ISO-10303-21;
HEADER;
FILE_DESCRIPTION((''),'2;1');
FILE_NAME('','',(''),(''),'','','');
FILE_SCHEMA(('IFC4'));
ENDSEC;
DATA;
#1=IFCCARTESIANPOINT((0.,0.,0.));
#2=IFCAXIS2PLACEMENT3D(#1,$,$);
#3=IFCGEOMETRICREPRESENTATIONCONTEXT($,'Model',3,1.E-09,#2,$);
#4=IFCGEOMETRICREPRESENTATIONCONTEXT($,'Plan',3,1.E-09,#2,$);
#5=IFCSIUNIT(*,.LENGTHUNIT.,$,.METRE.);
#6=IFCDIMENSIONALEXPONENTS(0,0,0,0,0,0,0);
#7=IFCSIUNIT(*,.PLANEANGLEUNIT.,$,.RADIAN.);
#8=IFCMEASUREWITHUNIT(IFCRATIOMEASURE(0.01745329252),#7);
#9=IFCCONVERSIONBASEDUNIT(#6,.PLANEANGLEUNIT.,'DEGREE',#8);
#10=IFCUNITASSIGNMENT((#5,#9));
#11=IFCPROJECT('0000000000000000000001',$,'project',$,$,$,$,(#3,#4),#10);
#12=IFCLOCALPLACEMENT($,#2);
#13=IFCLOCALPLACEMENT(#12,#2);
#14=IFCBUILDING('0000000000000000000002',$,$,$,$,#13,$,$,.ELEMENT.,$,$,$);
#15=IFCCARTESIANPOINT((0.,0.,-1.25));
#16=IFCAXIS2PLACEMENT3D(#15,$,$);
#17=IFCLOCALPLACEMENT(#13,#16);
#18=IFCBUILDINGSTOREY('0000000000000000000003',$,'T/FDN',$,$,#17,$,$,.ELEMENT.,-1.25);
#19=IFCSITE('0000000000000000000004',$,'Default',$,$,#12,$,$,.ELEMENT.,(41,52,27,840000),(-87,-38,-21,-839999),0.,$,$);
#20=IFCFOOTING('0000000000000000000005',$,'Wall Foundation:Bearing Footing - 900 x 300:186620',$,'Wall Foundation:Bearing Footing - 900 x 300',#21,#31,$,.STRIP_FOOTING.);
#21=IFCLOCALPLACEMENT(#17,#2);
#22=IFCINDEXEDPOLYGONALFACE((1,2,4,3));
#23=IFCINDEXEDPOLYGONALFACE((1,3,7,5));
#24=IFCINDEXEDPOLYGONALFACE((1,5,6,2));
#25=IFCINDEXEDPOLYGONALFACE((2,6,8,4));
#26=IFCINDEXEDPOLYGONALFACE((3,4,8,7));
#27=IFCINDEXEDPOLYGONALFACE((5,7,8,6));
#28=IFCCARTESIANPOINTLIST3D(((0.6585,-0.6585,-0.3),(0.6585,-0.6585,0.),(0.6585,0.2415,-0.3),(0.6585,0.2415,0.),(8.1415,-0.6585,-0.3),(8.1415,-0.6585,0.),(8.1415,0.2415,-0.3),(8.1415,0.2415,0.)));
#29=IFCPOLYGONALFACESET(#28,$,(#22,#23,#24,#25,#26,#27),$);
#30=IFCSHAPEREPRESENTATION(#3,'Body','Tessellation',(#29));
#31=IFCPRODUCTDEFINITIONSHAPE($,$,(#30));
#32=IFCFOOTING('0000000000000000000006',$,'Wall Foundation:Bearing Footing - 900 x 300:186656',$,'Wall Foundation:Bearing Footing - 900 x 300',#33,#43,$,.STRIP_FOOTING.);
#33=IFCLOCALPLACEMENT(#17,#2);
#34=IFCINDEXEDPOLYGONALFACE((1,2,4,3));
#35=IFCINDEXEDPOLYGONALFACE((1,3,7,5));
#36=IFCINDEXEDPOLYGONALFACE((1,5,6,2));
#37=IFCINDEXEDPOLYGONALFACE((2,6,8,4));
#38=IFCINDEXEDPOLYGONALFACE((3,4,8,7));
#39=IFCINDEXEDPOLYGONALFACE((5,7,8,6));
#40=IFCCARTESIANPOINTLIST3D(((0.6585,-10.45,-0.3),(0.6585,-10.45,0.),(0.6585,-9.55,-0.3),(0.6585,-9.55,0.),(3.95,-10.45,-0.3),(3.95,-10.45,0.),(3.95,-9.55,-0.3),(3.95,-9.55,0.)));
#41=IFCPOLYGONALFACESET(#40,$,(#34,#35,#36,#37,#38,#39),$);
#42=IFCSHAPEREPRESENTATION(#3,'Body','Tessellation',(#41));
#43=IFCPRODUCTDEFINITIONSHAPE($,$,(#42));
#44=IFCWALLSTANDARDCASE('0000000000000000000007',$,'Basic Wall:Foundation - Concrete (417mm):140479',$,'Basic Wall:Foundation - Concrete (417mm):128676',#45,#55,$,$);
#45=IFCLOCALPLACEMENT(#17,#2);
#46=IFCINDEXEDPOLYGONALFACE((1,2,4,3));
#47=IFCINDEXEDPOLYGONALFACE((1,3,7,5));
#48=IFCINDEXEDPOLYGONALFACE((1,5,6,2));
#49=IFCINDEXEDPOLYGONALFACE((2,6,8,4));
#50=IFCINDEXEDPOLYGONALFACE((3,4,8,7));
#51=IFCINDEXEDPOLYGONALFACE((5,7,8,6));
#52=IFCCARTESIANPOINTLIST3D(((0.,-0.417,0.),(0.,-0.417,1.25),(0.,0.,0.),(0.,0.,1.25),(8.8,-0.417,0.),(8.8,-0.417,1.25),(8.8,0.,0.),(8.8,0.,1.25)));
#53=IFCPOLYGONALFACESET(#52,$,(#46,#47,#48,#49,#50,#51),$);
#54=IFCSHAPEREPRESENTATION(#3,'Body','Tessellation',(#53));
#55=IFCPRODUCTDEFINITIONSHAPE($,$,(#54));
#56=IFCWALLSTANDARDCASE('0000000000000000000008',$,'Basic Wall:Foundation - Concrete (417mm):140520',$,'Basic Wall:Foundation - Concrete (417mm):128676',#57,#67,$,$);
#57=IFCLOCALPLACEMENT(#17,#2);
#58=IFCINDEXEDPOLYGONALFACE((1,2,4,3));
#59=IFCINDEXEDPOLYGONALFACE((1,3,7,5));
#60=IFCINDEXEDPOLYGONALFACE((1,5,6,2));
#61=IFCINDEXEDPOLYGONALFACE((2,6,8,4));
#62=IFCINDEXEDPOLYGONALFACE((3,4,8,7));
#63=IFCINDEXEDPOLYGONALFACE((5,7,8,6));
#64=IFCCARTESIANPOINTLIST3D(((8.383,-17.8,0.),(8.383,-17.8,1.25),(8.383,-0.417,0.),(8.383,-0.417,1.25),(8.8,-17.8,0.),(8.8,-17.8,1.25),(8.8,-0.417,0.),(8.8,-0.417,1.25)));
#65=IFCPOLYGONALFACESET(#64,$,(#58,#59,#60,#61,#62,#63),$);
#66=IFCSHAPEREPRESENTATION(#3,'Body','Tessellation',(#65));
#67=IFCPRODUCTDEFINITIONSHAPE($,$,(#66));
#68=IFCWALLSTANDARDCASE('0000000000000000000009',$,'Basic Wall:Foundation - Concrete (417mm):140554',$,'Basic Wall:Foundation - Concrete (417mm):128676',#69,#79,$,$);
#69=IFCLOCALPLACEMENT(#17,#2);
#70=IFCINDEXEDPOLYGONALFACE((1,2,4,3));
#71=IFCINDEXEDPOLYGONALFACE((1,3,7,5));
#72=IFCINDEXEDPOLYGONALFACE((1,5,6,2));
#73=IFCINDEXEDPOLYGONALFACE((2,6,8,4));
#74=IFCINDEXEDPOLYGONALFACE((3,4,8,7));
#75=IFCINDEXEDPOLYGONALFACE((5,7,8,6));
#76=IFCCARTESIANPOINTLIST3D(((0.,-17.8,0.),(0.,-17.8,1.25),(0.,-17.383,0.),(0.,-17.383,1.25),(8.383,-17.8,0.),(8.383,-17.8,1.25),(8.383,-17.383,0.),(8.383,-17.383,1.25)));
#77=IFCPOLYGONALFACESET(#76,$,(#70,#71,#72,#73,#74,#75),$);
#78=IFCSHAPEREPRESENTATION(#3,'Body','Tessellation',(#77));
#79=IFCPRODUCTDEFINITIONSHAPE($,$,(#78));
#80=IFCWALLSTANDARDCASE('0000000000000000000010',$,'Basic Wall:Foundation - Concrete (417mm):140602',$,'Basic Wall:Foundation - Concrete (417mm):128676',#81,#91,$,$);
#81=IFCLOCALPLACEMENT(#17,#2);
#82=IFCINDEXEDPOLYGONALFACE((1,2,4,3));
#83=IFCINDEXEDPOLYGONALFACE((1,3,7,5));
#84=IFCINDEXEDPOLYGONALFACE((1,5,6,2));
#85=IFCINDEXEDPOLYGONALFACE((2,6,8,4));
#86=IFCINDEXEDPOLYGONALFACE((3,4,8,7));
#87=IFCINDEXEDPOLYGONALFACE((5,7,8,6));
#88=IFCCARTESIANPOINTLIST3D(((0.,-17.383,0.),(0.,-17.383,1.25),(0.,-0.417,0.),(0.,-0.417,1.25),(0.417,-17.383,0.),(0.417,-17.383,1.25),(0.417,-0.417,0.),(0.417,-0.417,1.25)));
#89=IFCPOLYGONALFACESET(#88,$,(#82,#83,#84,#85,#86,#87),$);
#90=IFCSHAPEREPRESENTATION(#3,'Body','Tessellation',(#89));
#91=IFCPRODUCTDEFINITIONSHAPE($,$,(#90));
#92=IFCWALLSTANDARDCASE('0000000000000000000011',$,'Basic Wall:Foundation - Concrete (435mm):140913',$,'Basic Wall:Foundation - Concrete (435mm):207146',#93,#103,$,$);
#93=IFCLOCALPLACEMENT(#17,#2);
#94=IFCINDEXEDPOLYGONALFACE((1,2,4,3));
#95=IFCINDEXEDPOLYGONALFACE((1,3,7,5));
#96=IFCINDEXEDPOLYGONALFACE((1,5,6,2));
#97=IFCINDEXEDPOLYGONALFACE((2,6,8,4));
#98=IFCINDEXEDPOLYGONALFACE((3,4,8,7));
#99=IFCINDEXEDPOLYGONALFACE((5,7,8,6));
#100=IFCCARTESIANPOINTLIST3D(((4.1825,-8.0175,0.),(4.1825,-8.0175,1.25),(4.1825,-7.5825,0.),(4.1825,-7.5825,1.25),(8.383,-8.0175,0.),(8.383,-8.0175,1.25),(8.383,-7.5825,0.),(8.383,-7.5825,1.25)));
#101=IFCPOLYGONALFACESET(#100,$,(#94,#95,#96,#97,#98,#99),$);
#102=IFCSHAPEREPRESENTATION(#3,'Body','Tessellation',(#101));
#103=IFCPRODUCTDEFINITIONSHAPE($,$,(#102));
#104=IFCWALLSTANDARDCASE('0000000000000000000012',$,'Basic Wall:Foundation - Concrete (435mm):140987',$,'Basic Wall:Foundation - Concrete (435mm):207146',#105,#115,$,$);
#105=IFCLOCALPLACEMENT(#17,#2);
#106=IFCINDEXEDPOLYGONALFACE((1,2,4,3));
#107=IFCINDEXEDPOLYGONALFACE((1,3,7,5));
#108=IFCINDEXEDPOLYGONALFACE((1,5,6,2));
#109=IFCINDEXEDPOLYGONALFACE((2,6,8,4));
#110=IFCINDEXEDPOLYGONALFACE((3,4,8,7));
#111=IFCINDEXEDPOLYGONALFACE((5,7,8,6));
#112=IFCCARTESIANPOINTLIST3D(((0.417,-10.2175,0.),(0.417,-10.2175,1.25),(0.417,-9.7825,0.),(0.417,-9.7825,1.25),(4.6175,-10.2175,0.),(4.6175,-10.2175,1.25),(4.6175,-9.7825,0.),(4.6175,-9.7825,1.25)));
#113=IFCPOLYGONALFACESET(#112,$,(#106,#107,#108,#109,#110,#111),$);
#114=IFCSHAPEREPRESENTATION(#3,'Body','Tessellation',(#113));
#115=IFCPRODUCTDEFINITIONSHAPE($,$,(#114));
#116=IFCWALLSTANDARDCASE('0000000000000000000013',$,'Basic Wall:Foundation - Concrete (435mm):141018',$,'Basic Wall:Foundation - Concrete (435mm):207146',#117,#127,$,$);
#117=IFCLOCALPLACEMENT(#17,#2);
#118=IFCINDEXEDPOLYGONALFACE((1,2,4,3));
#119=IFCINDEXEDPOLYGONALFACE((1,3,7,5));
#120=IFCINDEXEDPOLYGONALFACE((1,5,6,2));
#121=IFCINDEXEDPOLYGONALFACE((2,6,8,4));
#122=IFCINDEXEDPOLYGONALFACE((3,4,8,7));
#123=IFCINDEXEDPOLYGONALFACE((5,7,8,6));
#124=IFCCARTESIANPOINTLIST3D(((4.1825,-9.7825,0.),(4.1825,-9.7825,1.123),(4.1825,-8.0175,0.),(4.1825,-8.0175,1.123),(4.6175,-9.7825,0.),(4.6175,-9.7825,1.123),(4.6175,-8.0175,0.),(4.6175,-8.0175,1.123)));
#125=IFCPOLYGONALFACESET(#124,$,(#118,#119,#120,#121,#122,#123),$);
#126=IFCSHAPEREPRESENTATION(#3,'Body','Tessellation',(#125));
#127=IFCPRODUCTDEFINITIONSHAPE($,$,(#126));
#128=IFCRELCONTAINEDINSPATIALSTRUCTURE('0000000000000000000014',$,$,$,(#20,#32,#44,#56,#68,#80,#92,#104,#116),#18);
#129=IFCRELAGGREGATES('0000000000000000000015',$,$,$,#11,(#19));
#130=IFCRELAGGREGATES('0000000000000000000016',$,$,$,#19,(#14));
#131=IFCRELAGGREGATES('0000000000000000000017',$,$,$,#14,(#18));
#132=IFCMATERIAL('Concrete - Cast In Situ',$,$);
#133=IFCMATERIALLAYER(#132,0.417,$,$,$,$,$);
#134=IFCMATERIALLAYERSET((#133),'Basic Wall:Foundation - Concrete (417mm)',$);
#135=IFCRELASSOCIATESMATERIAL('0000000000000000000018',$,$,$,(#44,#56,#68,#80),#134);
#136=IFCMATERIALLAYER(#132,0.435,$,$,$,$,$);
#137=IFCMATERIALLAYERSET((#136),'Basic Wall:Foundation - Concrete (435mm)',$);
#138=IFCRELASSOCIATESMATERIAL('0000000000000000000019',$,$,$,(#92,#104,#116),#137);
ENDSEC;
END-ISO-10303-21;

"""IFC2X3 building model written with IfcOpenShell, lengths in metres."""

from ifc_helpers import new_model, entity, si_unit, converted_unit, frame, frame_2d, origin, origin_2d_with_axis, place, context, project, spatial, rectangle, extrude, material, layer, layer_set, layer_usage, element, save


model = new_model("IFC2X3")

# Units and contexts
model_context = context("Model", 3, precision=1e-09, world=origin())
plan_context = context("Plan", 3, precision=1e-09, world=origin())
ifc_project = project(units=[si_unit("LENGTHUNIT", "METRE"), converted_unit("PLANEANGLEUNIT", "DEGREE", entity("IfcRatioMeasure", 0.01745329252), si_unit("PLANEANGLEUNIT", "RADIAN"), dimensions=[0, 0, 0, 0, 0, 0, 0])], contexts=[model_context, plan_context])

# Site, building, storey
site_placement = place(None, origin())
site = spatial("IfcSite", under=ifc_project, at=site_placement, Name="Default", CompositionType="ELEMENT", RefLatitude=(41, 52, 27, 840000), RefLongitude=(-87, -38, -21, -839999), RefElevation=0.0)
building_placement = place(site_placement, origin())
building = spatial("IfcBuilding", under=site, at=building_placement, CompositionType="ELEMENT")
storey_placement = place(building_placement, frame((0.0, 0.0, -1.25)))
storey = spatial("IfcBuildingStorey", under=building, at=storey_placement, Name="T/FDN", CompositionType="ELEMENT", Elevation=-1.25)

# Footings
footing_1_placement = place(storey_placement, origin())
element("IfcFooting", 1, at=footing_1_placement, inside=storey, Name="Wall Foundation:Bearing Footing - 900 x 300:186620", ObjectType="Wall Foundation:Bearing Footing - 900 x 300", PredefinedType="STRIP_FOOTING", context=model_context, shape_type="SweptSolid", body=[
    extrude(rectangle(XDim=7.483, YDim=0.9, at=origin_2d_with_axis()), frame((4.4, -0.2085, -0.3), z_axis=(0.0, 0.0, 1.0), x_axis=(-1.0, 0.0, 0.0)), (0.0, 0.0, 1.0), 0.3),
])
footing_2_placement = place(storey_placement, origin())
element("IfcFooting", 2, at=footing_2_placement, inside=storey, Name="Wall Foundation:Bearing Footing - 900 x 300:186656", ObjectType="Wall Foundation:Bearing Footing - 900 x 300", PredefinedType="STRIP_FOOTING", context=model_context, shape_type="SweptSolid", body=[
    extrude(rectangle(XDim=3.2915, YDim=0.9, at=origin_2d_with_axis()), frame((2.3043, -10.0, -0.3)), (0.0, 0.0, 1.0), 0.3),
])

# Walls
ifc_material = material(Name="Concrete - Cast In Situ")
ifc_layer_1 = layer(ifc_material, 0.417)
ifc_layer_set_1 = layer_set([ifc_layer_1], Name="Basic Wall:Foundation - Concrete (417mm)")
ifc_layer_usage_1 = layer_usage(ifc_layer_set_1, "AXIS2", "NEGATIVE", 0.2085)
wall_1_placement = place(storey_placement, frame((0.0, -0.2085, 0.0)))
element("IfcWallStandardCase", 3, at=wall_1_placement, inside=storey, material=ifc_layer_usage_1, Name="Basic Wall:Foundation - Concrete (417mm):140479", ObjectType="Basic Wall:Foundation - Concrete (417mm):128676", context=model_context, shape_type="SweptSolid", body=[
    extrude(rectangle(XDim=8.8, YDim=0.417, at=frame_2d((4.4, 0.0), x_axis=(-1.0, 0.0))), origin(), (0.0, 0.0, 1.0), 1.25),
])
ifc_layer_usage_2 = layer_usage(ifc_layer_set_1, "AXIS2", "NEGATIVE", 0.2085)
wall_2_placement = place(storey_placement, frame((8.5915, -0.417, 0.0), z_axis=(0.0, 0.0, 1.0), x_axis=(0.0, -1.0, 0.0)))
element("IfcWallStandardCase", 4, at=wall_2_placement, inside=storey, material=ifc_layer_usage_2, Name="Basic Wall:Foundation - Concrete (417mm):140520", ObjectType="Basic Wall:Foundation - Concrete (417mm):128676", context=model_context, shape_type="SweptSolid", body=[
    extrude(rectangle(XDim=17.383, YDim=0.417, at=frame_2d((8.6915, 0.0), x_axis=(-1.0, 0.0))), origin(), (0.0, 0.0, 1.0), 1.25),
])
ifc_layer_usage_3 = layer_usage(ifc_layer_set_1, "AXIS2", "NEGATIVE", 0.2085)
wall_3_placement = place(storey_placement, frame((8.383, -17.5915, 0.0), z_axis=(0.0, 0.0, 1.0), x_axis=(-1.0, 0.0, 0.0)))
element("IfcWallStandardCase", 5, at=wall_3_placement, inside=storey, material=ifc_layer_usage_3, Name="Basic Wall:Foundation - Concrete (417mm):140554", ObjectType="Basic Wall:Foundation - Concrete (417mm):128676", context=model_context, shape_type="SweptSolid", body=[
    extrude(rectangle(XDim=8.383, YDim=0.417, at=frame_2d((4.1915, 0.0), x_axis=(-1.0, 0.0))), origin(), (0.0, 0.0, 1.0), 1.25),
])
ifc_layer_usage_4 = layer_usage(ifc_layer_set_1, "AXIS2", "NEGATIVE", 0.2085)
wall_4_placement = place(storey_placement, frame((0.2085, -17.383, 0.0), z_axis=(0.0, 0.0, 1.0), x_axis=(0.0, 1.0, 0.0)))
element("IfcWallStandardCase", 6, at=wall_4_placement, inside=storey, material=ifc_layer_usage_4, Name="Basic Wall:Foundation - Concrete (417mm):140602", ObjectType="Basic Wall:Foundation - Concrete (417mm):128676", context=model_context, shape_type="SweptSolid", body=[
    extrude(rectangle(XDim=16.966, YDim=0.417, at=frame_2d((8.483, 0.0), x_axis=(-1.0, 0.0))), origin(), (0.0, 0.0, 1.0), 1.25),
])
ifc_layer_2 = layer(ifc_material, 0.435)
ifc_layer_set_2 = layer_set([ifc_layer_2], Name="Basic Wall:Foundation - Concrete (435mm)")
ifc_layer_usage_5 = layer_usage(ifc_layer_set_2, "AXIS2", "NEGATIVE", 0.2175)
wall_5_placement = place(storey_placement, frame((8.383, -7.8, 0.0), z_axis=(0.0, 0.0, 1.0), x_axis=(-1.0, 0.0, 0.0)))
element("IfcWallStandardCase", 7, at=wall_5_placement, inside=storey, material=ifc_layer_usage_5, Name="Basic Wall:Foundation - Concrete (435mm):140913", ObjectType="Basic Wall:Foundation - Concrete (435mm):207146", context=model_context, shape_type="SweptSolid", body=[
    extrude(rectangle(XDim=4.2005, YDim=0.435, at=frame_2d((2.1002, 0.0), x_axis=(-1.0, 0.0))), origin(), (0.0, 0.0, 1.0), 1.25),
])
ifc_layer_usage_6 = layer_usage(ifc_layer_set_2, "AXIS2", "NEGATIVE", 0.2175)
wall_6_placement = place(storey_placement, frame((0.417, -10.0, 0.0)))
element("IfcWallStandardCase", 8, at=wall_6_placement, inside=storey, material=ifc_layer_usage_6, Name="Basic Wall:Foundation - Concrete (435mm):140987", ObjectType="Basic Wall:Foundation - Concrete (435mm):207146", context=model_context, shape_type="SweptSolid", body=[
    extrude(rectangle(XDim=4.2005, YDim=0.435, at=frame_2d((2.1002, 0.0), x_axis=(-1.0, 0.0))), origin(), (0.0, 0.0, 1.0), 1.25),
])
ifc_layer_usage_7 = layer_usage(ifc_layer_set_2, "AXIS2", "NEGATIVE", 0.2175)
wall_7_placement = place(storey_placement, frame((4.4, -9.7825, 0.0), z_axis=(0.0, 0.0, 1.0), x_axis=(0.0, 1.0, 0.0)))
element("IfcWallStandardCase", 9, at=wall_7_placement, inside=storey, material=ifc_layer_usage_7, Name="Basic Wall:Foundation - Concrete (435mm):141018", ObjectType="Basic Wall:Foundation - Concrete (435mm):207146", context=model_context, shape_type="SweptSolid", body=[
    extrude(rectangle(XDim=1.765, YDim=0.435, at=frame_2d((0.8825, 0.0), x_axis=(-1.0, 0.0))), origin(), (0.0, 0.0, 1.0), 1.123),
])

save(model, "model.ifc")
